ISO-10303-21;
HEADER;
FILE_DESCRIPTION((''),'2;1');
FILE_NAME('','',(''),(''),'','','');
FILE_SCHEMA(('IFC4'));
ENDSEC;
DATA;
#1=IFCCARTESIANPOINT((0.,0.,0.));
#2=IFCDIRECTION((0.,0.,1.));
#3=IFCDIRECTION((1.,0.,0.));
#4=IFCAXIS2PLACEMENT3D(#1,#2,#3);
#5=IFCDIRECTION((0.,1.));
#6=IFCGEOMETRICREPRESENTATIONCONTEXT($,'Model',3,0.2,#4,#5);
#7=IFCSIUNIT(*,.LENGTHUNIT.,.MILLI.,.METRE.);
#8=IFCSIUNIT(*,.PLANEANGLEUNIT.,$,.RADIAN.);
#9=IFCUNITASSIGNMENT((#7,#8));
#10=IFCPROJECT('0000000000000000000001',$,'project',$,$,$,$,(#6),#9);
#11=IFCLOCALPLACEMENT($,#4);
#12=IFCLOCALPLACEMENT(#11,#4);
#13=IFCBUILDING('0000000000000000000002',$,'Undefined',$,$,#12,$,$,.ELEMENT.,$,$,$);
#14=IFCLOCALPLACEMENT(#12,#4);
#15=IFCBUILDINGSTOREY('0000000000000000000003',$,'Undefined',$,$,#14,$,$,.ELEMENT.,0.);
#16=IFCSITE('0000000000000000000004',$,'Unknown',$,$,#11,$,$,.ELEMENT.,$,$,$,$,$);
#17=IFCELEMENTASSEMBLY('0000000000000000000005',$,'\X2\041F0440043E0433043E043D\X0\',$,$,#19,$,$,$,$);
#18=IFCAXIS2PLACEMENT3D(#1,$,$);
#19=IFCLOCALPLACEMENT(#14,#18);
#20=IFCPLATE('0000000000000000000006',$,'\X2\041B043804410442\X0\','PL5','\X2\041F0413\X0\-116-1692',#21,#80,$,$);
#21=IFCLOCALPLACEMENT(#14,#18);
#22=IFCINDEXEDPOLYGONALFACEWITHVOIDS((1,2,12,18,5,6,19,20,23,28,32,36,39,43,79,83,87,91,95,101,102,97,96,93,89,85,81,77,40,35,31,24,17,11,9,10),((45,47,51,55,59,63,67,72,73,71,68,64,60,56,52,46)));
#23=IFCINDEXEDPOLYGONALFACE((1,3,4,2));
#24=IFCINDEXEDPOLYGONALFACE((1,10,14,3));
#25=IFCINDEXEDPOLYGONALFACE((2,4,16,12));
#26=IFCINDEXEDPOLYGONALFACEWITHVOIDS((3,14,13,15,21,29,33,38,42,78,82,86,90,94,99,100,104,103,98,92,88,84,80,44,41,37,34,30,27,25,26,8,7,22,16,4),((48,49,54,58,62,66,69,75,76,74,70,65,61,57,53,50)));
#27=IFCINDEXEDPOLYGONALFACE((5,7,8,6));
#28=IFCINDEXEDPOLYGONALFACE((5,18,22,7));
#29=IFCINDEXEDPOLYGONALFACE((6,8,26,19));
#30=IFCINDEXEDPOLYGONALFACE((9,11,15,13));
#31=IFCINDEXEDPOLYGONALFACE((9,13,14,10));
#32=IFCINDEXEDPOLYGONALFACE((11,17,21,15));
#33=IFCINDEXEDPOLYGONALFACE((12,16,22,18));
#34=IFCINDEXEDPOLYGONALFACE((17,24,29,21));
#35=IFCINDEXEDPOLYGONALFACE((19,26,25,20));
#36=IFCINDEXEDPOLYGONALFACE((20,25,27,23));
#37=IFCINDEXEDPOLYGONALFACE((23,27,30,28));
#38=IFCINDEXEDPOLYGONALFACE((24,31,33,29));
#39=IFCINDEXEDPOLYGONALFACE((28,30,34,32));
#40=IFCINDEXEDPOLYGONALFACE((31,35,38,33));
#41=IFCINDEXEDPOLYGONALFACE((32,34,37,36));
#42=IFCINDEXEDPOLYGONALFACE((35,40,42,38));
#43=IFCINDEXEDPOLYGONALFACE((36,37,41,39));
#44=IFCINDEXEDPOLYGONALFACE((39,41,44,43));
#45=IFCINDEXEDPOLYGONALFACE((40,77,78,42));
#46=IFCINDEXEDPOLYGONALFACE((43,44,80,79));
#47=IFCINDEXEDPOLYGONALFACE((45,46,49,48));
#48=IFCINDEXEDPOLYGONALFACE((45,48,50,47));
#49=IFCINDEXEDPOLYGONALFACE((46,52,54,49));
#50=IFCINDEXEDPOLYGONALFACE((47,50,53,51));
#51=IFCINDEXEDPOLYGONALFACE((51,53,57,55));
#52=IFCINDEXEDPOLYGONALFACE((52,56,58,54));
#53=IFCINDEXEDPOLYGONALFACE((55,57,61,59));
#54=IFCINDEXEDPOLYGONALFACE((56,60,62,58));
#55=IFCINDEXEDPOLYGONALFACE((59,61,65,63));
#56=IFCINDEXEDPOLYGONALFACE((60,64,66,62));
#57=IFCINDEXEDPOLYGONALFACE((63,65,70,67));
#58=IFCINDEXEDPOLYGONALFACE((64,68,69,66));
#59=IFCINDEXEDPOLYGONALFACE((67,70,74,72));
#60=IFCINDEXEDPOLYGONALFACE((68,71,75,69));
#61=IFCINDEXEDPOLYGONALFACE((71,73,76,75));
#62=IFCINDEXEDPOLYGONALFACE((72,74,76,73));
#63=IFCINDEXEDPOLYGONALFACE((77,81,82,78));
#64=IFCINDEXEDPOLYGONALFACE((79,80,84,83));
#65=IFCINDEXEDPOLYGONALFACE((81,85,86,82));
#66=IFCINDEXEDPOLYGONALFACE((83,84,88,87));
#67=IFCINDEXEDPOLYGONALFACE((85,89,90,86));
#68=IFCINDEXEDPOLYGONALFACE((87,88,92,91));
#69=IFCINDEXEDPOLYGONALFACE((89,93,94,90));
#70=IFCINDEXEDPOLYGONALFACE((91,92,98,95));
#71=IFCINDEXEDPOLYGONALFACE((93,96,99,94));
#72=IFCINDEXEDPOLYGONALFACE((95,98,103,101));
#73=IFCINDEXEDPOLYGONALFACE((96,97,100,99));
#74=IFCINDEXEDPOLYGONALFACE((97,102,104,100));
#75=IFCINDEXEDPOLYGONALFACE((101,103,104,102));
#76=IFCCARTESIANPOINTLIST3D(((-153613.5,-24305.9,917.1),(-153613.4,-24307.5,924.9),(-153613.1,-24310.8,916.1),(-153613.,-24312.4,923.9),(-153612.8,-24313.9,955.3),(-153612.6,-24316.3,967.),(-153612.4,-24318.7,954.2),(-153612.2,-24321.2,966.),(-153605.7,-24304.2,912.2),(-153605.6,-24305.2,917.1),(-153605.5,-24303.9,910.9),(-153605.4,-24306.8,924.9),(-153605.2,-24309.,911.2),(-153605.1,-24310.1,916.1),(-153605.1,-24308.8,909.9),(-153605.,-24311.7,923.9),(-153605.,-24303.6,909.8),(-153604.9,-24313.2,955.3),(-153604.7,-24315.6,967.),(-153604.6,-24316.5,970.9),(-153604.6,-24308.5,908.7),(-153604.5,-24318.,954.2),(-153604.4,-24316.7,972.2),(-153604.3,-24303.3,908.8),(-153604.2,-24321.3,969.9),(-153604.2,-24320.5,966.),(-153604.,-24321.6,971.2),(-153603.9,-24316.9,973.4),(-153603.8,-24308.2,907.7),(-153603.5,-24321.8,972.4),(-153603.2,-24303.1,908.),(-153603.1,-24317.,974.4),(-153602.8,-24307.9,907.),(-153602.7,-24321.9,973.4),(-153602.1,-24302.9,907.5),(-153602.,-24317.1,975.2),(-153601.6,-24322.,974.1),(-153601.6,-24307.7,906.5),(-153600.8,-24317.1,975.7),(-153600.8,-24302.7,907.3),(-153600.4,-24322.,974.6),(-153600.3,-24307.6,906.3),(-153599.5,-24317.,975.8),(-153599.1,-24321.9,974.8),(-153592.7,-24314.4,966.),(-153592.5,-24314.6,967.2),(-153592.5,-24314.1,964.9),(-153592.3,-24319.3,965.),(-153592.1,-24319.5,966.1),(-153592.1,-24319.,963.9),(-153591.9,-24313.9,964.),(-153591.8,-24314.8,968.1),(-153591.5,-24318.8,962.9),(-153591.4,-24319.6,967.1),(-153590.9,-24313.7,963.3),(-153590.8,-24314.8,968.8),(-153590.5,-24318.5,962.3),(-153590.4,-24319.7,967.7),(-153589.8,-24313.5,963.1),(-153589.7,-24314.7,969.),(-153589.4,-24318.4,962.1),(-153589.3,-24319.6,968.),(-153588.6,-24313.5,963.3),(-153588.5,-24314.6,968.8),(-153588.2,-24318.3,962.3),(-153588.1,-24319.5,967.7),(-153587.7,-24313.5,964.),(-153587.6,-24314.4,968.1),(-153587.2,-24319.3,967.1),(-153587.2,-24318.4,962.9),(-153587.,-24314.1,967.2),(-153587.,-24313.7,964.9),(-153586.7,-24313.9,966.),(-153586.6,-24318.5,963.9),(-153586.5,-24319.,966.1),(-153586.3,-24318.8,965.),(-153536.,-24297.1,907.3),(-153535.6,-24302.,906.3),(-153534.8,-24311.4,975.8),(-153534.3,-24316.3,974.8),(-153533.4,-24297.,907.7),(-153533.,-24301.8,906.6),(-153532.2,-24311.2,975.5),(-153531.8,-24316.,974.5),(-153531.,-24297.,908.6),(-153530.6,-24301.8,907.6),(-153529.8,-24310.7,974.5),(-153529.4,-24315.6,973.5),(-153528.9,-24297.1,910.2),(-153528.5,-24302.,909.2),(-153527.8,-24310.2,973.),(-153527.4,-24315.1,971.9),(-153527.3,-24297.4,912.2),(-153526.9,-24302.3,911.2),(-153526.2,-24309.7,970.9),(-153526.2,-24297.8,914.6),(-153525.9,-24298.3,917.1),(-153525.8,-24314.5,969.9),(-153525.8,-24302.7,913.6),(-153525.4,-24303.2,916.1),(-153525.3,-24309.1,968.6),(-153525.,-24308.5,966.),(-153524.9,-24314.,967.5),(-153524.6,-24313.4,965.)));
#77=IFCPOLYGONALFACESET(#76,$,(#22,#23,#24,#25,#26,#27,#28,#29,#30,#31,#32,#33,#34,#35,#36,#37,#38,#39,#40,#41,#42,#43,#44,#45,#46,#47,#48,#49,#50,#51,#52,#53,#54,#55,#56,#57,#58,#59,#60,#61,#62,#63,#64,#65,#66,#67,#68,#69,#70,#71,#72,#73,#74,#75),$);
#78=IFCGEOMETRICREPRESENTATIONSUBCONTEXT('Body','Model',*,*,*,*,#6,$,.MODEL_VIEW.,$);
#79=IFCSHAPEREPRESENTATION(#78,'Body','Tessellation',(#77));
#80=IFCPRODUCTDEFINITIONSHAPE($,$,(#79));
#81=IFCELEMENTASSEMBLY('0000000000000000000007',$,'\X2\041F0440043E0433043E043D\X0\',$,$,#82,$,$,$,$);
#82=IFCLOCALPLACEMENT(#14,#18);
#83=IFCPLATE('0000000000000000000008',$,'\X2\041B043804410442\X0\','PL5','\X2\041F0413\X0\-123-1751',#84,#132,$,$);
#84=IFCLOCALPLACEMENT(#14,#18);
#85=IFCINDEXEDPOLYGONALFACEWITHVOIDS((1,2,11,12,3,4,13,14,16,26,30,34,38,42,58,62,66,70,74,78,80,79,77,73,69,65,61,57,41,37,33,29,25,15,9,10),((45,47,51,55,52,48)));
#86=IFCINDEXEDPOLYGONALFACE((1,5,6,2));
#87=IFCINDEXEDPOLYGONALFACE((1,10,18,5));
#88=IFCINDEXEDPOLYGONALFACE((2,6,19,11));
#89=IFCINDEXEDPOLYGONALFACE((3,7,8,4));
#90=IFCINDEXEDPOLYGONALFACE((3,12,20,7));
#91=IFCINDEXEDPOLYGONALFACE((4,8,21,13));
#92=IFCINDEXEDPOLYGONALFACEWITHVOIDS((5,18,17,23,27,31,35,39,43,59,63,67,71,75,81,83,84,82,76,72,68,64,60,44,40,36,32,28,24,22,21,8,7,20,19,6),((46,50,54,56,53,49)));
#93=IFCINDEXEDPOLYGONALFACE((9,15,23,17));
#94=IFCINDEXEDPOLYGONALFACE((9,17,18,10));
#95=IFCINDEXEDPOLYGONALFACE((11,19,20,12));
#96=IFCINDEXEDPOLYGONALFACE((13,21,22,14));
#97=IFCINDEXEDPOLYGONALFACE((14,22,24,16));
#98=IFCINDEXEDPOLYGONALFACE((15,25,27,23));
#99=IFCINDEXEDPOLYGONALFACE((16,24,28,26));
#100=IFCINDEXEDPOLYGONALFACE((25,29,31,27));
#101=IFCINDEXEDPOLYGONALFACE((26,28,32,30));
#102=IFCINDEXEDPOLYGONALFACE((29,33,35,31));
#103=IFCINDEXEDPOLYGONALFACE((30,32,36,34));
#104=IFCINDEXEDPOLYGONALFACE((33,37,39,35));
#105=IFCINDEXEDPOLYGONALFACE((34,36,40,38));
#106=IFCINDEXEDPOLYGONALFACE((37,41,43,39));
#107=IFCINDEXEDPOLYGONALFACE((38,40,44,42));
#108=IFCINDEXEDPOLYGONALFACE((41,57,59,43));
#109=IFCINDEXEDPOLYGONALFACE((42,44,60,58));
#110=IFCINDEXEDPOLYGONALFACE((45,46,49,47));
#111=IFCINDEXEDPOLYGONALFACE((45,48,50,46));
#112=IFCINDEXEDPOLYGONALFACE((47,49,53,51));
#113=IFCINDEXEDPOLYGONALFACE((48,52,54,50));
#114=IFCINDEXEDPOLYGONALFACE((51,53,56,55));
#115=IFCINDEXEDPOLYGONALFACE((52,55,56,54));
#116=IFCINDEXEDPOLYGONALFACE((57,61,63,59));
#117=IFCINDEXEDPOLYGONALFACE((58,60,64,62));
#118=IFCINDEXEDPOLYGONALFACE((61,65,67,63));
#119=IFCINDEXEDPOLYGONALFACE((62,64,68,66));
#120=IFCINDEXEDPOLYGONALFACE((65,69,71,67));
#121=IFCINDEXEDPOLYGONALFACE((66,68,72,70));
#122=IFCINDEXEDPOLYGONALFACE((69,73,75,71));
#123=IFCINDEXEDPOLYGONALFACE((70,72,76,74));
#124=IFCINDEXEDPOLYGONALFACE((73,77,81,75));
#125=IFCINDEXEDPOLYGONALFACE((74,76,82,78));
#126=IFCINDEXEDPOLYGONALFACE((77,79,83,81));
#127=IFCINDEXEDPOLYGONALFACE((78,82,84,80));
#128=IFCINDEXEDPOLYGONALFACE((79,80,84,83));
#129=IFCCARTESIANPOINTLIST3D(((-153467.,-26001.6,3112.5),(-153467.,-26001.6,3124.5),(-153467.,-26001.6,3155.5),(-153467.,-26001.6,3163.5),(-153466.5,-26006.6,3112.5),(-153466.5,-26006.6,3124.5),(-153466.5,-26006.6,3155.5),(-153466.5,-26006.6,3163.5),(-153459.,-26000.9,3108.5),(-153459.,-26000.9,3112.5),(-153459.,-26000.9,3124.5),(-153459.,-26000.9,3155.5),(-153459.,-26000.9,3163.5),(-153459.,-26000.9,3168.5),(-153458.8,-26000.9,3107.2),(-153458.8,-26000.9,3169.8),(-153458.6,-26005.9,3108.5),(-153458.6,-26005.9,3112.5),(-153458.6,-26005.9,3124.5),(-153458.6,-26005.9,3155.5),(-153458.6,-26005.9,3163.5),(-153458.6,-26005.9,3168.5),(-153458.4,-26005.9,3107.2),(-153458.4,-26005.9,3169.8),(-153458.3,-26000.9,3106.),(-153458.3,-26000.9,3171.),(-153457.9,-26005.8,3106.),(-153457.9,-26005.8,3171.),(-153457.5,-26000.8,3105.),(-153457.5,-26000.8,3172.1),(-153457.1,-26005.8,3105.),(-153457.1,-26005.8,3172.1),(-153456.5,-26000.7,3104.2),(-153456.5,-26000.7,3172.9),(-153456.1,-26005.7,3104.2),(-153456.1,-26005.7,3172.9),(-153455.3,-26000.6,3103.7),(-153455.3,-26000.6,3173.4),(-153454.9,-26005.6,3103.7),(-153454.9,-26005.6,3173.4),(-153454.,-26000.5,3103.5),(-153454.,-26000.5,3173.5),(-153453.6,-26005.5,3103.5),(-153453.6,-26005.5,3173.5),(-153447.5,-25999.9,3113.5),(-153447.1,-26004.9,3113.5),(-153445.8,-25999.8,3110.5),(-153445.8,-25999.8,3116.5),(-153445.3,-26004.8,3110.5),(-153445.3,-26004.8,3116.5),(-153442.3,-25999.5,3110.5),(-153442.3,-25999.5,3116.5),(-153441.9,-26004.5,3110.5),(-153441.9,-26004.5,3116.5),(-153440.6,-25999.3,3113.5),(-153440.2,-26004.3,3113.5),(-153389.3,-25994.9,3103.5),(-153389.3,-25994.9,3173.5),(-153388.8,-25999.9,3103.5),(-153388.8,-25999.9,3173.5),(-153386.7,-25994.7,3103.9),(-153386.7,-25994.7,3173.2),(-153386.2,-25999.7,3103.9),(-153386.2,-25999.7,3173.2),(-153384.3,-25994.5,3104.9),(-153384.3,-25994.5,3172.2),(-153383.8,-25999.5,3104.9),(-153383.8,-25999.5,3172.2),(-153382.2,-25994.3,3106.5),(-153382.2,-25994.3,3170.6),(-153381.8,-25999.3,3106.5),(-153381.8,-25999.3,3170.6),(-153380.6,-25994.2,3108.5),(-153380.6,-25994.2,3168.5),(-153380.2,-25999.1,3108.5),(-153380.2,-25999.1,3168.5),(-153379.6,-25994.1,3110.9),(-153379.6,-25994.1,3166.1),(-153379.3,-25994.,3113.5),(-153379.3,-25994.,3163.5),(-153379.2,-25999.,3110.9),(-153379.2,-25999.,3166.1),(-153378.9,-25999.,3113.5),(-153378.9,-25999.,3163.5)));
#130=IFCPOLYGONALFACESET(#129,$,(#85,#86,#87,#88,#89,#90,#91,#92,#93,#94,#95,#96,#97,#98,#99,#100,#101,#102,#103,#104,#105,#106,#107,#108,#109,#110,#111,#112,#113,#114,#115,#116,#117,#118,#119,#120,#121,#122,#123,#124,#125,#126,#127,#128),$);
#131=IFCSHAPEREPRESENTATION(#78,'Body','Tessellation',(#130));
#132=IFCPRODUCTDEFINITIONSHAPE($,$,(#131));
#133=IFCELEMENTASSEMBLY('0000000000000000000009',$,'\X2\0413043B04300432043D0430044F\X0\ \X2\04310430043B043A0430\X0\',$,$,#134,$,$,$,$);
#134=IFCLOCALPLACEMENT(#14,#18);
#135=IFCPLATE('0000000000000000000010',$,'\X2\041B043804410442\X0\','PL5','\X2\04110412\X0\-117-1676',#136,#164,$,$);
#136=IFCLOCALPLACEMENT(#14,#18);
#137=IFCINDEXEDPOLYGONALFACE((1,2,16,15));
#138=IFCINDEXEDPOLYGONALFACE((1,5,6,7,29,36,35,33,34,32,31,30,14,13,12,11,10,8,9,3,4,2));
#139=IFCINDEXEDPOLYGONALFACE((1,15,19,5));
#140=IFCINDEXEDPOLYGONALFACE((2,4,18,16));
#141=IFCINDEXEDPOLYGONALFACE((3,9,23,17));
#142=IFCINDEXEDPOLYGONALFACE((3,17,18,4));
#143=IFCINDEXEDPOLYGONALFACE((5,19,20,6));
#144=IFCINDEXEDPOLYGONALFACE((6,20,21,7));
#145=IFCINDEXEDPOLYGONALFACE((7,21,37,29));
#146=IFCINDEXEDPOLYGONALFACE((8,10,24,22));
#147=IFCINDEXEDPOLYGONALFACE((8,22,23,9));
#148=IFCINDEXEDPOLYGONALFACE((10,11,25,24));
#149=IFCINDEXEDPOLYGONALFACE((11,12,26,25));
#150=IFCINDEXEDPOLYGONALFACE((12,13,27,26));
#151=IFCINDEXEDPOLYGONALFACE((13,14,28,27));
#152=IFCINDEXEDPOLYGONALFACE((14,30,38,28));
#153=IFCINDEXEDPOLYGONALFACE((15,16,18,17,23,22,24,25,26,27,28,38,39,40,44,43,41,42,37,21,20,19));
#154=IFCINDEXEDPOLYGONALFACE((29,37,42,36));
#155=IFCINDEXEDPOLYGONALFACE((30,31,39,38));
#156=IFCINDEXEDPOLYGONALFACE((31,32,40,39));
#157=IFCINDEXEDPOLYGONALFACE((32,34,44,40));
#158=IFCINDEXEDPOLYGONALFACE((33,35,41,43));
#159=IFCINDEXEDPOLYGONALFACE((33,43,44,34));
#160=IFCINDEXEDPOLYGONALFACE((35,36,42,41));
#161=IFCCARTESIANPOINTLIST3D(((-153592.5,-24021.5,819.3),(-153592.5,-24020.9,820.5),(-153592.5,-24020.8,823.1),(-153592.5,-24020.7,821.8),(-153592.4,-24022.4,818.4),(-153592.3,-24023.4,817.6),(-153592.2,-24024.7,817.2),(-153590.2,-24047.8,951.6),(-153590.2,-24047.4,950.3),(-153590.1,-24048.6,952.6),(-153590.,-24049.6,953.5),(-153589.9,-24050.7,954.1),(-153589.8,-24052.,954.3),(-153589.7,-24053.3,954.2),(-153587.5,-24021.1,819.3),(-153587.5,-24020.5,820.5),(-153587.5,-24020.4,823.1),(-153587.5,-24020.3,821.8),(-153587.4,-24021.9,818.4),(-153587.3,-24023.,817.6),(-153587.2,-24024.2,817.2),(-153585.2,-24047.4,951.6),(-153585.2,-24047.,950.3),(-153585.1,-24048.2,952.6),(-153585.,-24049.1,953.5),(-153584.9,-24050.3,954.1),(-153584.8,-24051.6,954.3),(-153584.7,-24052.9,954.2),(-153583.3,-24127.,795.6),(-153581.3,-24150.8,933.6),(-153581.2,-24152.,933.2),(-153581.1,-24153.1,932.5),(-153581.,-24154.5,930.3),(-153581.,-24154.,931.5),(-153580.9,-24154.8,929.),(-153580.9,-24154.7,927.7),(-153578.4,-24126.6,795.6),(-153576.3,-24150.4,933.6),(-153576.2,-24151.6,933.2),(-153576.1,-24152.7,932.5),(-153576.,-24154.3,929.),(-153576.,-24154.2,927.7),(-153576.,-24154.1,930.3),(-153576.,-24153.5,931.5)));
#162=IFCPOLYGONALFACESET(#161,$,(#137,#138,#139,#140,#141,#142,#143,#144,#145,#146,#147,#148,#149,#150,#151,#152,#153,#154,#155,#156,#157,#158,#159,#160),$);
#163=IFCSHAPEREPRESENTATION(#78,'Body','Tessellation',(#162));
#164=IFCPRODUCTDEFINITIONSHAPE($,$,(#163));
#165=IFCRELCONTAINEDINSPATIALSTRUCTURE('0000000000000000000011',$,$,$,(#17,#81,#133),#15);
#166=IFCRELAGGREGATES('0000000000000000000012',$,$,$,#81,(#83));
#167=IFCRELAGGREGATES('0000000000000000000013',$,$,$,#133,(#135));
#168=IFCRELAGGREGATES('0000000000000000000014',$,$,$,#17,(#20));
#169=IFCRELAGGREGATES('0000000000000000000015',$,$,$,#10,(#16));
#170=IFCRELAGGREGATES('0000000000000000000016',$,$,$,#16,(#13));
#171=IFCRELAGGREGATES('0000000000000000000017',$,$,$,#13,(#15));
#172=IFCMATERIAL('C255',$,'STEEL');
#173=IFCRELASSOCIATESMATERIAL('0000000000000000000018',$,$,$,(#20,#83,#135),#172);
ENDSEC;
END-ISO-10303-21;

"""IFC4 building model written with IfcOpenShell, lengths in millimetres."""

from ifc_helpers import new_model, si_unit, direction, frame, origin_with_axes, place, context, subcontext, project, spatial, line, arc, indexed_curve, outline, extrude, material, element, aggregate, save


model = new_model("IFC4")

# Units and contexts
model_context = context("Model", 3, precision=0.2, world=origin_with_axes(), true_north=direction((0.0, 1.0)))
body_context = subcontext(model_context, "Body", "Model", "MODEL_VIEW")
ifc_project = project(units=[si_unit("LENGTHUNIT", "METRE", prefix="MILLI"), si_unit("PLANEANGLEUNIT", "RADIAN")], contexts=[model_context])

# Site, building, storey
site_placement = place(None, origin_with_axes())
site = spatial("IfcSite", under=ifc_project, at=site_placement, Name="Unknown", CompositionType="ELEMENT")
building_placement = place(site_placement, origin_with_axes())
building = spatial("IfcBuilding", under=site, at=building_placement, Name="Undefined", CompositionType="ELEMENT")
storey_placement = place(building_placement, origin_with_axes())
storey = spatial("IfcBuildingStorey", under=building, at=storey_placement, Name="Undefined", CompositionType="ELEMENT", Elevation=0.0)

# Shared definitions
ifc_material_1 = material(Name="C255", Category="STEEL")

# Element assembly, plate, voiding feature
assembly_1_placement = place(storey_placement, frame((-153645.0, -24313.2, 533.0), z_axis=(0.086114, -0.996285, 0.0), x_axis=(0.0, 0.0, 1.0)))
assembly_1 = element("IfcElementAssembly", 1, at=assembly_1_placement, inside=storey, Name="Прогон")
plate_1_placement = place(assembly_1_placement, frame((373.8, -120.0, -4.2), z_axis=(-0.205517, -0.000052, 0.978653), x_axis=(0.978653, 0.00003, 0.205517)))
plate_1 = element("IfcPlate", 2, at=plate_1_placement, material=ifc_material_1, Name="Лист", Description="PL5", ObjectType="ПГ-116-1692", context=body_context, shape_type="SolidModel", body=[
    extrude(outline(indexed_curve([(0.0, 10.0), (2.9, 2.9), (10.0, 0.0), (60.0, 0.0), (67.1, 2.9), (70.0, 10.0), (70.0, 75.0), (68.5, 78.5), (65.0, 80.0), (61.0, 80.0), (61.0, 88.0), (49.0, 88.0), (49.0, 80.0), (18.0, 80.0), (18.0, 88.0), (10.0, 88.0), (10.0, 80.0), (5.0, 80.0), (1.5, 78.5), (0.0, 75.0)], segments=[arc(1, 2, 3), line(3, 4), arc(4, 5, 6), line(6, 7), arc(7, 8, 9), line(9, 10, 11, 12, 13, 14, 15, 16, 17, 18), arc(18, 19, 20), line(20, 1)])), frame((0.0, 0.0, 2.5), z_axis=(0.0, 0.0, 1.0), x_axis=(1.0, 0.0, 0.0)), (0.0, 0.0, -1.0), 5.0),
])
voiding_feature_1_placement = place(plate_1_placement, frame((60.0, 65.0, 6.0), z_axis=(-0.000054, -1.0, 0.000034), x_axis=(0.0, -0.000034, -1.0)))
element("IfcVoidingFeature", 3, at=voiding_feature_1_placement, cuts=plate_1, Name="Балка", ObjectType="(?)", PredefinedType="HOLE", context=body_context, shape_type="SolidModel", body=[
    extrude(outline(indexed_curve([(3.0, 0.0), (2.8, 1.1), (2.1, 2.1), (1.1, 2.8), (0.0, 3.0), (-1.1, 2.8), (-2.1, 2.1), (-2.8, 1.1), (-3.0, 0.0), (-2.8, -1.1), (-2.1, -2.1), (-1.1, -2.8), (0.0, -3.0), (1.1, -2.8), (2.1, -2.1), (2.8, -1.1)], segments=[line(1, 2, 3, 4, 5, 6, 7, 8, 9, 10, 11, 12, 13, 14, 15, 16, 1)])), frame((0.0, 0.0, 0.0), z_axis=(-1.0, 0.0, 0.0), x_axis=(0.0, 0.0, 1.0)), (0.0, 0.0, -1.0), 12.0),
])

# Element assembly, plate, voiding feature
assembly_2_placement = place(storey_placement, frame((-153498.6, -26006.9, 89.2), z_axis=(0.086114, -0.996285, 0.0), x_axis=(0.0, 0.0, 1.0)))
assembly_2 = element("IfcElementAssembly", 4, at=assembly_2_placement, inside=storey, Name="Прогон")
plate_2_placement = place(assembly_2_placement, frame((3084.3, -120.0, 0.0), z_axis=(0.0, -0.000057, -1.0), x_axis=(-1.0, 0.000024, 0.0)))
plate_2 = element("IfcPlate", 5, at=plate_2_placement, material=ifc_material_1, Name="Лист", Description="PL5", ObjectType="ПГ-123-1751", context=body_context, shape_type="SolidModel", body=[
    extrude(outline(indexed_curve([(0.0, 10.0), (2.9, 2.9), (10.0, 0.0), (60.0, 0.0), (67.1, 2.9), (70.0, 10.0), (70.0, 75.0), (68.5, 78.5), (65.0, 80.0), (61.0, 80.0), (61.0, 88.0), (49.0, 88.0), (49.0, 80.0), (18.0, 80.0), (18.0, 88.0), (10.0, 88.0), (10.0, 80.0), (5.0, 80.0), (1.5, 78.5), (0.0, 75.0)], segments=[arc(1, 2, 3), line(3, 4), arc(4, 5, 6), line(6, 7), arc(7, 8, 9), line(9, 10, 11, 12, 13, 14, 15, 16, 17, 18), arc(18, 19, 20), line(20, 1)])), frame((0.0, 0.0, 2.5), z_axis=(0.0, 0.0, 1.0), x_axis=(1.0, 0.0, 0.0)), (0.0, 0.0, -1.0), 5.0),
])
voiding_feature_2_placement = place(plate_2_placement, frame((60.0, 65.0, 6.0), z_axis=(-0.000054, -1.0, 0.000034), x_axis=(0.0, -0.000034, -1.0)))
element("IfcVoidingFeature", 6, at=voiding_feature_2_placement, cuts=plate_2, Name="Балка", ObjectType="(?)", PredefinedType="HOLE", context=body_context, shape_type="SolidModel", body=[
    extrude(outline(indexed_curve([(1.7, -3.0), (3.5, 0.0), (1.7, 3.0), (-1.7, 3.0), (-3.5, 0.0), (-1.7, -3.0)], segments=[line(1, 2, 3, 4, 5, 6, 1)])), frame((0.0, 0.0, 0.0), z_axis=(-1.0, 0.0, 0.0), x_axis=(0.0, 0.0, 1.0)), (0.0, 0.0, -1.0), 12.0),
])
aggregate(assembly_2, [plate_2])

# Element assembly, plate
assembly_3_placement = place(storey_placement, frame((-153597.0, -23940.1, 906.5), z_axis=(-0.996285, -0.086114, 0.000024), x_axis=(0.084276, -0.975018, -0.205517)))
assembly_3 = element("IfcElementAssembly", 7, at=assembly_3_placement, inside=storey, Name="Главная балка")
plate_3_placement = place(assembly_3_placement, frame((96.2, 70.0, 0.0), z_axis=(0.0, 0.0, 1.0), x_axis=(0.0, -1.0, 0.0)))
plate_3 = element("IfcPlate", 8, at=plate_3_placement, material=ifc_material_1, Name="Лист", Description="PL5", ObjectType="БВ-117-1676", context=body_context, shape_type="SolidModel", body=[
    extrude(outline(indexed_curve([(0.0, 5.0), (1.5, 1.5), (5.0, 0.0), (135.0, 0.0), (138.5, 1.5), (140.0, 5.0), (140.0, 110.0), (5.0, 110.0), (1.5, 108.5), (0.0, 105.0)], segments=[arc(1, 2, 3), line(3, 4), arc(4, 5, 6), line(6, 7, 8), arc(8, 9, 10), line(10, 1)])), frame((0.0, 0.0, 2.5), z_axis=(0.0, 0.0, 1.0), x_axis=(1.0, 0.0, 0.0)), (0.0, 0.0, -1.0), 5.0),
])
aggregate(assembly_3, [plate_3])

aggregate(assembly_1, [plate_1])

save(model, "model.ifc")
